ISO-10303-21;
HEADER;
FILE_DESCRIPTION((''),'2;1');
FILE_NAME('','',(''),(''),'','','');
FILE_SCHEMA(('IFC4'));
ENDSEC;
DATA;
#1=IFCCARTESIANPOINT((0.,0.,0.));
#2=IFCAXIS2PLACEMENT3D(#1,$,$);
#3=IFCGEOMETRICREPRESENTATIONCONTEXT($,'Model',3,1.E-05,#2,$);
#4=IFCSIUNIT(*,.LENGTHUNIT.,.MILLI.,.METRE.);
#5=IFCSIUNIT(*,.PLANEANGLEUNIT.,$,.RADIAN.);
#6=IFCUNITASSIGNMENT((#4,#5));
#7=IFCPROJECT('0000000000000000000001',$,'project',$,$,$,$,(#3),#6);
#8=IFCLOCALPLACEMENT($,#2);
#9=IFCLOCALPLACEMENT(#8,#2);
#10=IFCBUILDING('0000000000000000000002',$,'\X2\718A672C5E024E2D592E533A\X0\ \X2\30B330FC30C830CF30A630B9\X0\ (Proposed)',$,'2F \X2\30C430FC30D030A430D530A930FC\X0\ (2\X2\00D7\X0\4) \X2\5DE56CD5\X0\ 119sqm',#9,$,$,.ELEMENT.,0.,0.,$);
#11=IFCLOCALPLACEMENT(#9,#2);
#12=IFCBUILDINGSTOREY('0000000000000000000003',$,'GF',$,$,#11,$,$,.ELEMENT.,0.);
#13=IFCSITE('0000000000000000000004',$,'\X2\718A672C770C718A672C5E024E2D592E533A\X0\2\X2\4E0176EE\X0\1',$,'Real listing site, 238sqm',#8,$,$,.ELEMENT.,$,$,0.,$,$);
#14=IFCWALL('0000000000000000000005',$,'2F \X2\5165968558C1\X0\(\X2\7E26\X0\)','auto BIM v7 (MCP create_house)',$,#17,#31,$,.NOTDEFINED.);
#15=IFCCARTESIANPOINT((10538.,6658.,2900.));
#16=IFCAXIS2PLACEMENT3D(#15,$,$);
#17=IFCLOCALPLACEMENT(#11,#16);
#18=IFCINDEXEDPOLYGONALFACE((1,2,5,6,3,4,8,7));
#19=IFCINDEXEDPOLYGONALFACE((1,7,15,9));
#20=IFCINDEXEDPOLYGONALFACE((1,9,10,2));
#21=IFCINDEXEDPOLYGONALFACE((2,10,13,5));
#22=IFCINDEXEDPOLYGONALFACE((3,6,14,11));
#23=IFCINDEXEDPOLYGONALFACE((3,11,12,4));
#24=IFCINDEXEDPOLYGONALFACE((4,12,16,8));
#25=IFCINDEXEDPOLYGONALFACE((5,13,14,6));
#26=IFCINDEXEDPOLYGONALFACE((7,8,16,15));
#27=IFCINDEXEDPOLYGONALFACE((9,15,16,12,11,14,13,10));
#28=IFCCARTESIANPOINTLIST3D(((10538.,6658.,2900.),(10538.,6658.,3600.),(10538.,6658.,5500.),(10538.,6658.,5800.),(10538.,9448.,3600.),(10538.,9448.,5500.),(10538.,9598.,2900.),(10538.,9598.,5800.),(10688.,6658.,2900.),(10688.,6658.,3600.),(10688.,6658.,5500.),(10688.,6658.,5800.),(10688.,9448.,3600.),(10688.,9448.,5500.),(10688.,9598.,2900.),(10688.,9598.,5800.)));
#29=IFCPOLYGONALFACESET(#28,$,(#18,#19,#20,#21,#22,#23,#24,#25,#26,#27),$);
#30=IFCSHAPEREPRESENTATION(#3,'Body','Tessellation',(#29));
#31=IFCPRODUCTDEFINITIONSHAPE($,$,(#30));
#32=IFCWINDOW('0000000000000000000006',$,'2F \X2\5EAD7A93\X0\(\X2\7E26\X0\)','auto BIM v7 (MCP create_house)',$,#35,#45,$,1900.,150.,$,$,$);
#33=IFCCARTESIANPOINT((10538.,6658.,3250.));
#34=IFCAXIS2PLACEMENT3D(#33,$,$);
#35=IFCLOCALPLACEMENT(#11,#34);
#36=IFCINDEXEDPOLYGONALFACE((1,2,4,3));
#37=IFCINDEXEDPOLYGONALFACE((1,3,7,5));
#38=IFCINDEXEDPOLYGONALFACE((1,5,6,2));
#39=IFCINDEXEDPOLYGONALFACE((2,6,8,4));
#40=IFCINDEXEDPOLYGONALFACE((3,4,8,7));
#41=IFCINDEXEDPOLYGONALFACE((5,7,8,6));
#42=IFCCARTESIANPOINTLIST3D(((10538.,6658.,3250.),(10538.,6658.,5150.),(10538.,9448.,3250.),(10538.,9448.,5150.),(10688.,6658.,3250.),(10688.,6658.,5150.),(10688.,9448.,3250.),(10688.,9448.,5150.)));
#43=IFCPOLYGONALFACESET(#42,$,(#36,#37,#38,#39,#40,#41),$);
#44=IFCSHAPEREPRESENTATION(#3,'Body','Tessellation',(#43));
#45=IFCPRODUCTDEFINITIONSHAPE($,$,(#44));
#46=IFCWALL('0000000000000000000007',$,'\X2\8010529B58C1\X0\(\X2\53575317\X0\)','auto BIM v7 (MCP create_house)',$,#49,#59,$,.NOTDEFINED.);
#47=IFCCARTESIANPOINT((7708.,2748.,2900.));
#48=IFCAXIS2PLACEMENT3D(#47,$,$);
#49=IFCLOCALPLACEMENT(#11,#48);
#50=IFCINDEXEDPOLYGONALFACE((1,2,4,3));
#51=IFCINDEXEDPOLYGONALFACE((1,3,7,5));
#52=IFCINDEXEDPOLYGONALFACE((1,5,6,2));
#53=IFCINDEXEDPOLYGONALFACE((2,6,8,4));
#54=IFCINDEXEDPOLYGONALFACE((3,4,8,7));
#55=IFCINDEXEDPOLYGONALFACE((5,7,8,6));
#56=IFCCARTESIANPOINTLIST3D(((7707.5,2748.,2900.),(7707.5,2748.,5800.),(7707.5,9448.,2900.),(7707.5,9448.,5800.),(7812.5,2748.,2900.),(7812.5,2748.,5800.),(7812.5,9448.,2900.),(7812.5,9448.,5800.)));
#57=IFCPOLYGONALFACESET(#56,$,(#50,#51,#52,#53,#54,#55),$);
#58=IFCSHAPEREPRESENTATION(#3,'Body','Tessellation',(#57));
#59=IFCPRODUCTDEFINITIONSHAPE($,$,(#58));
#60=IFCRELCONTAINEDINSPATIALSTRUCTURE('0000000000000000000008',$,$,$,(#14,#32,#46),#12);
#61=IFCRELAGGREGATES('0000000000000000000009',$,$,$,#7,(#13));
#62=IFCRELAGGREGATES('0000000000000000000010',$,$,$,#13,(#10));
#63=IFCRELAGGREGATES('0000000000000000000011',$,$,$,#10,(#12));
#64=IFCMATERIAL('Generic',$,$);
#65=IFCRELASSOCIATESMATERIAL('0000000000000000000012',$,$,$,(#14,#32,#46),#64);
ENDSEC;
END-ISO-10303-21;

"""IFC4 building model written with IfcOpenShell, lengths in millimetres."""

from ifc_helpers import new_model, si_unit, frame, frame_2d, origin, place, context, project, spatial, rectangle, extrude, material, element, fill, save


model = new_model("IFC4")

# Units and contexts
model_context = context("Model", 3, precision=1e-05, world=origin())
ifc_project = project(units=[si_unit("LENGTHUNIT", "METRE", prefix="MILLI"), si_unit("PLANEANGLEUNIT", "RADIAN")], contexts=[model_context])

# Site, building, storey
site_placement = place(None, origin())
site = spatial("IfcSite", under=ifc_project, at=site_placement, Name="熊本県熊本市中央区2丁目1", ObjectType="Real listing site, 238sqm", CompositionType="ELEMENT", RefElevation=0.0)
building_placement = place(site_placement, origin())
building = spatial("IfcBuilding", under=site, at=building_placement, Name="熊本市中央区 コートハウス (Proposed)", ObjectType="2F ツーバイフォー (2×4) 工法 119sqm", CompositionType="ELEMENT", ElevationOfRefHeight=0.0, ElevationOfTerrain=0.0)
storey_placement = place(building_placement, origin())
storey = spatial("IfcBuildingStorey", under=building, at=storey_placement, Name="GF", CompositionType="ELEMENT", Elevation=0.0)

# Shared definitions
ifc_material = material(Name="Generic")

# Wall, opening, window
wall_1_placement = place(storey_placement, frame((10538.0, 6658.0, 2900.0)))
wall_1 = element("IfcWall", 1, at=wall_1_placement, inside=storey, material=ifc_material, Name="2F 入隅壁(縦)", Description="auto BIM v7 (MCP create_house)", PredefinedType="NOTDEFINED", context=model_context, shape_type="SweptSolid", body=[
    extrude(rectangle(XDim=150.0, YDim=2940.0, at=frame_2d((75.0, 1470.0))), frame((10538.0, 6658.0, 2900.0)), (0.0, 0.0, 1.0), 2900.0),
])
opening_1_placement = place(storey_placement, frame((10538.0, 6658.0, 3250.0)))
opening_1 = element("IfcOpeningElement", 2, at=opening_1_placement, cuts=wall_1, PredefinedType="NOTDEFINED", context=model_context, shape_type="SweptSolid", body=[
    extrude(rectangle(XDim=150.0, YDim=2790.0, at=frame_2d((75.0, 1395.0))), frame((10538.0, 6658.0, 3250.0)), (0.0, 0.0, 1.0), 1900.0),
])
window_1_placement = place(storey_placement, frame((10538.0, 6658.0, 3250.0)))
window_1 = element("IfcWindow", 3, at=window_1_placement, inside=storey, material=ifc_material, Name="2F 庭窓(縦)", Description="auto BIM v7 (MCP create_house)", OverallHeight=1900.0, OverallWidth=150.0, context=model_context, shape_type="SweptSolid", body=[
    extrude(rectangle(XDim=150.0, YDim=2790.0, at=frame_2d((75.0, 1395.0))), frame((10538.0, 6658.0, 3250.0)), (0.0, 0.0, 1.0), 1900.0),
])
fill(opening_1, window_1)

# Wall
wall_2_placement = place(storey_placement, frame((7708.0, 2748.0, 2900.0)))
element("IfcWall", 4, at=wall_2_placement, inside=storey, material=ifc_material, Name="耐力壁(南北)", Description="auto BIM v7 (MCP create_house)", PredefinedType="NOTDEFINED", context=model_context, shape_type="SweptSolid", body=[
    extrude(rectangle(XDim=105.0, YDim=6700.0, at=frame_2d((52.0, 3350.0))), frame((7708.0, 2748.0, 2900.0)), (0.0, 0.0, 1.0), 2900.0),
])

save(model, "model.ifc")
